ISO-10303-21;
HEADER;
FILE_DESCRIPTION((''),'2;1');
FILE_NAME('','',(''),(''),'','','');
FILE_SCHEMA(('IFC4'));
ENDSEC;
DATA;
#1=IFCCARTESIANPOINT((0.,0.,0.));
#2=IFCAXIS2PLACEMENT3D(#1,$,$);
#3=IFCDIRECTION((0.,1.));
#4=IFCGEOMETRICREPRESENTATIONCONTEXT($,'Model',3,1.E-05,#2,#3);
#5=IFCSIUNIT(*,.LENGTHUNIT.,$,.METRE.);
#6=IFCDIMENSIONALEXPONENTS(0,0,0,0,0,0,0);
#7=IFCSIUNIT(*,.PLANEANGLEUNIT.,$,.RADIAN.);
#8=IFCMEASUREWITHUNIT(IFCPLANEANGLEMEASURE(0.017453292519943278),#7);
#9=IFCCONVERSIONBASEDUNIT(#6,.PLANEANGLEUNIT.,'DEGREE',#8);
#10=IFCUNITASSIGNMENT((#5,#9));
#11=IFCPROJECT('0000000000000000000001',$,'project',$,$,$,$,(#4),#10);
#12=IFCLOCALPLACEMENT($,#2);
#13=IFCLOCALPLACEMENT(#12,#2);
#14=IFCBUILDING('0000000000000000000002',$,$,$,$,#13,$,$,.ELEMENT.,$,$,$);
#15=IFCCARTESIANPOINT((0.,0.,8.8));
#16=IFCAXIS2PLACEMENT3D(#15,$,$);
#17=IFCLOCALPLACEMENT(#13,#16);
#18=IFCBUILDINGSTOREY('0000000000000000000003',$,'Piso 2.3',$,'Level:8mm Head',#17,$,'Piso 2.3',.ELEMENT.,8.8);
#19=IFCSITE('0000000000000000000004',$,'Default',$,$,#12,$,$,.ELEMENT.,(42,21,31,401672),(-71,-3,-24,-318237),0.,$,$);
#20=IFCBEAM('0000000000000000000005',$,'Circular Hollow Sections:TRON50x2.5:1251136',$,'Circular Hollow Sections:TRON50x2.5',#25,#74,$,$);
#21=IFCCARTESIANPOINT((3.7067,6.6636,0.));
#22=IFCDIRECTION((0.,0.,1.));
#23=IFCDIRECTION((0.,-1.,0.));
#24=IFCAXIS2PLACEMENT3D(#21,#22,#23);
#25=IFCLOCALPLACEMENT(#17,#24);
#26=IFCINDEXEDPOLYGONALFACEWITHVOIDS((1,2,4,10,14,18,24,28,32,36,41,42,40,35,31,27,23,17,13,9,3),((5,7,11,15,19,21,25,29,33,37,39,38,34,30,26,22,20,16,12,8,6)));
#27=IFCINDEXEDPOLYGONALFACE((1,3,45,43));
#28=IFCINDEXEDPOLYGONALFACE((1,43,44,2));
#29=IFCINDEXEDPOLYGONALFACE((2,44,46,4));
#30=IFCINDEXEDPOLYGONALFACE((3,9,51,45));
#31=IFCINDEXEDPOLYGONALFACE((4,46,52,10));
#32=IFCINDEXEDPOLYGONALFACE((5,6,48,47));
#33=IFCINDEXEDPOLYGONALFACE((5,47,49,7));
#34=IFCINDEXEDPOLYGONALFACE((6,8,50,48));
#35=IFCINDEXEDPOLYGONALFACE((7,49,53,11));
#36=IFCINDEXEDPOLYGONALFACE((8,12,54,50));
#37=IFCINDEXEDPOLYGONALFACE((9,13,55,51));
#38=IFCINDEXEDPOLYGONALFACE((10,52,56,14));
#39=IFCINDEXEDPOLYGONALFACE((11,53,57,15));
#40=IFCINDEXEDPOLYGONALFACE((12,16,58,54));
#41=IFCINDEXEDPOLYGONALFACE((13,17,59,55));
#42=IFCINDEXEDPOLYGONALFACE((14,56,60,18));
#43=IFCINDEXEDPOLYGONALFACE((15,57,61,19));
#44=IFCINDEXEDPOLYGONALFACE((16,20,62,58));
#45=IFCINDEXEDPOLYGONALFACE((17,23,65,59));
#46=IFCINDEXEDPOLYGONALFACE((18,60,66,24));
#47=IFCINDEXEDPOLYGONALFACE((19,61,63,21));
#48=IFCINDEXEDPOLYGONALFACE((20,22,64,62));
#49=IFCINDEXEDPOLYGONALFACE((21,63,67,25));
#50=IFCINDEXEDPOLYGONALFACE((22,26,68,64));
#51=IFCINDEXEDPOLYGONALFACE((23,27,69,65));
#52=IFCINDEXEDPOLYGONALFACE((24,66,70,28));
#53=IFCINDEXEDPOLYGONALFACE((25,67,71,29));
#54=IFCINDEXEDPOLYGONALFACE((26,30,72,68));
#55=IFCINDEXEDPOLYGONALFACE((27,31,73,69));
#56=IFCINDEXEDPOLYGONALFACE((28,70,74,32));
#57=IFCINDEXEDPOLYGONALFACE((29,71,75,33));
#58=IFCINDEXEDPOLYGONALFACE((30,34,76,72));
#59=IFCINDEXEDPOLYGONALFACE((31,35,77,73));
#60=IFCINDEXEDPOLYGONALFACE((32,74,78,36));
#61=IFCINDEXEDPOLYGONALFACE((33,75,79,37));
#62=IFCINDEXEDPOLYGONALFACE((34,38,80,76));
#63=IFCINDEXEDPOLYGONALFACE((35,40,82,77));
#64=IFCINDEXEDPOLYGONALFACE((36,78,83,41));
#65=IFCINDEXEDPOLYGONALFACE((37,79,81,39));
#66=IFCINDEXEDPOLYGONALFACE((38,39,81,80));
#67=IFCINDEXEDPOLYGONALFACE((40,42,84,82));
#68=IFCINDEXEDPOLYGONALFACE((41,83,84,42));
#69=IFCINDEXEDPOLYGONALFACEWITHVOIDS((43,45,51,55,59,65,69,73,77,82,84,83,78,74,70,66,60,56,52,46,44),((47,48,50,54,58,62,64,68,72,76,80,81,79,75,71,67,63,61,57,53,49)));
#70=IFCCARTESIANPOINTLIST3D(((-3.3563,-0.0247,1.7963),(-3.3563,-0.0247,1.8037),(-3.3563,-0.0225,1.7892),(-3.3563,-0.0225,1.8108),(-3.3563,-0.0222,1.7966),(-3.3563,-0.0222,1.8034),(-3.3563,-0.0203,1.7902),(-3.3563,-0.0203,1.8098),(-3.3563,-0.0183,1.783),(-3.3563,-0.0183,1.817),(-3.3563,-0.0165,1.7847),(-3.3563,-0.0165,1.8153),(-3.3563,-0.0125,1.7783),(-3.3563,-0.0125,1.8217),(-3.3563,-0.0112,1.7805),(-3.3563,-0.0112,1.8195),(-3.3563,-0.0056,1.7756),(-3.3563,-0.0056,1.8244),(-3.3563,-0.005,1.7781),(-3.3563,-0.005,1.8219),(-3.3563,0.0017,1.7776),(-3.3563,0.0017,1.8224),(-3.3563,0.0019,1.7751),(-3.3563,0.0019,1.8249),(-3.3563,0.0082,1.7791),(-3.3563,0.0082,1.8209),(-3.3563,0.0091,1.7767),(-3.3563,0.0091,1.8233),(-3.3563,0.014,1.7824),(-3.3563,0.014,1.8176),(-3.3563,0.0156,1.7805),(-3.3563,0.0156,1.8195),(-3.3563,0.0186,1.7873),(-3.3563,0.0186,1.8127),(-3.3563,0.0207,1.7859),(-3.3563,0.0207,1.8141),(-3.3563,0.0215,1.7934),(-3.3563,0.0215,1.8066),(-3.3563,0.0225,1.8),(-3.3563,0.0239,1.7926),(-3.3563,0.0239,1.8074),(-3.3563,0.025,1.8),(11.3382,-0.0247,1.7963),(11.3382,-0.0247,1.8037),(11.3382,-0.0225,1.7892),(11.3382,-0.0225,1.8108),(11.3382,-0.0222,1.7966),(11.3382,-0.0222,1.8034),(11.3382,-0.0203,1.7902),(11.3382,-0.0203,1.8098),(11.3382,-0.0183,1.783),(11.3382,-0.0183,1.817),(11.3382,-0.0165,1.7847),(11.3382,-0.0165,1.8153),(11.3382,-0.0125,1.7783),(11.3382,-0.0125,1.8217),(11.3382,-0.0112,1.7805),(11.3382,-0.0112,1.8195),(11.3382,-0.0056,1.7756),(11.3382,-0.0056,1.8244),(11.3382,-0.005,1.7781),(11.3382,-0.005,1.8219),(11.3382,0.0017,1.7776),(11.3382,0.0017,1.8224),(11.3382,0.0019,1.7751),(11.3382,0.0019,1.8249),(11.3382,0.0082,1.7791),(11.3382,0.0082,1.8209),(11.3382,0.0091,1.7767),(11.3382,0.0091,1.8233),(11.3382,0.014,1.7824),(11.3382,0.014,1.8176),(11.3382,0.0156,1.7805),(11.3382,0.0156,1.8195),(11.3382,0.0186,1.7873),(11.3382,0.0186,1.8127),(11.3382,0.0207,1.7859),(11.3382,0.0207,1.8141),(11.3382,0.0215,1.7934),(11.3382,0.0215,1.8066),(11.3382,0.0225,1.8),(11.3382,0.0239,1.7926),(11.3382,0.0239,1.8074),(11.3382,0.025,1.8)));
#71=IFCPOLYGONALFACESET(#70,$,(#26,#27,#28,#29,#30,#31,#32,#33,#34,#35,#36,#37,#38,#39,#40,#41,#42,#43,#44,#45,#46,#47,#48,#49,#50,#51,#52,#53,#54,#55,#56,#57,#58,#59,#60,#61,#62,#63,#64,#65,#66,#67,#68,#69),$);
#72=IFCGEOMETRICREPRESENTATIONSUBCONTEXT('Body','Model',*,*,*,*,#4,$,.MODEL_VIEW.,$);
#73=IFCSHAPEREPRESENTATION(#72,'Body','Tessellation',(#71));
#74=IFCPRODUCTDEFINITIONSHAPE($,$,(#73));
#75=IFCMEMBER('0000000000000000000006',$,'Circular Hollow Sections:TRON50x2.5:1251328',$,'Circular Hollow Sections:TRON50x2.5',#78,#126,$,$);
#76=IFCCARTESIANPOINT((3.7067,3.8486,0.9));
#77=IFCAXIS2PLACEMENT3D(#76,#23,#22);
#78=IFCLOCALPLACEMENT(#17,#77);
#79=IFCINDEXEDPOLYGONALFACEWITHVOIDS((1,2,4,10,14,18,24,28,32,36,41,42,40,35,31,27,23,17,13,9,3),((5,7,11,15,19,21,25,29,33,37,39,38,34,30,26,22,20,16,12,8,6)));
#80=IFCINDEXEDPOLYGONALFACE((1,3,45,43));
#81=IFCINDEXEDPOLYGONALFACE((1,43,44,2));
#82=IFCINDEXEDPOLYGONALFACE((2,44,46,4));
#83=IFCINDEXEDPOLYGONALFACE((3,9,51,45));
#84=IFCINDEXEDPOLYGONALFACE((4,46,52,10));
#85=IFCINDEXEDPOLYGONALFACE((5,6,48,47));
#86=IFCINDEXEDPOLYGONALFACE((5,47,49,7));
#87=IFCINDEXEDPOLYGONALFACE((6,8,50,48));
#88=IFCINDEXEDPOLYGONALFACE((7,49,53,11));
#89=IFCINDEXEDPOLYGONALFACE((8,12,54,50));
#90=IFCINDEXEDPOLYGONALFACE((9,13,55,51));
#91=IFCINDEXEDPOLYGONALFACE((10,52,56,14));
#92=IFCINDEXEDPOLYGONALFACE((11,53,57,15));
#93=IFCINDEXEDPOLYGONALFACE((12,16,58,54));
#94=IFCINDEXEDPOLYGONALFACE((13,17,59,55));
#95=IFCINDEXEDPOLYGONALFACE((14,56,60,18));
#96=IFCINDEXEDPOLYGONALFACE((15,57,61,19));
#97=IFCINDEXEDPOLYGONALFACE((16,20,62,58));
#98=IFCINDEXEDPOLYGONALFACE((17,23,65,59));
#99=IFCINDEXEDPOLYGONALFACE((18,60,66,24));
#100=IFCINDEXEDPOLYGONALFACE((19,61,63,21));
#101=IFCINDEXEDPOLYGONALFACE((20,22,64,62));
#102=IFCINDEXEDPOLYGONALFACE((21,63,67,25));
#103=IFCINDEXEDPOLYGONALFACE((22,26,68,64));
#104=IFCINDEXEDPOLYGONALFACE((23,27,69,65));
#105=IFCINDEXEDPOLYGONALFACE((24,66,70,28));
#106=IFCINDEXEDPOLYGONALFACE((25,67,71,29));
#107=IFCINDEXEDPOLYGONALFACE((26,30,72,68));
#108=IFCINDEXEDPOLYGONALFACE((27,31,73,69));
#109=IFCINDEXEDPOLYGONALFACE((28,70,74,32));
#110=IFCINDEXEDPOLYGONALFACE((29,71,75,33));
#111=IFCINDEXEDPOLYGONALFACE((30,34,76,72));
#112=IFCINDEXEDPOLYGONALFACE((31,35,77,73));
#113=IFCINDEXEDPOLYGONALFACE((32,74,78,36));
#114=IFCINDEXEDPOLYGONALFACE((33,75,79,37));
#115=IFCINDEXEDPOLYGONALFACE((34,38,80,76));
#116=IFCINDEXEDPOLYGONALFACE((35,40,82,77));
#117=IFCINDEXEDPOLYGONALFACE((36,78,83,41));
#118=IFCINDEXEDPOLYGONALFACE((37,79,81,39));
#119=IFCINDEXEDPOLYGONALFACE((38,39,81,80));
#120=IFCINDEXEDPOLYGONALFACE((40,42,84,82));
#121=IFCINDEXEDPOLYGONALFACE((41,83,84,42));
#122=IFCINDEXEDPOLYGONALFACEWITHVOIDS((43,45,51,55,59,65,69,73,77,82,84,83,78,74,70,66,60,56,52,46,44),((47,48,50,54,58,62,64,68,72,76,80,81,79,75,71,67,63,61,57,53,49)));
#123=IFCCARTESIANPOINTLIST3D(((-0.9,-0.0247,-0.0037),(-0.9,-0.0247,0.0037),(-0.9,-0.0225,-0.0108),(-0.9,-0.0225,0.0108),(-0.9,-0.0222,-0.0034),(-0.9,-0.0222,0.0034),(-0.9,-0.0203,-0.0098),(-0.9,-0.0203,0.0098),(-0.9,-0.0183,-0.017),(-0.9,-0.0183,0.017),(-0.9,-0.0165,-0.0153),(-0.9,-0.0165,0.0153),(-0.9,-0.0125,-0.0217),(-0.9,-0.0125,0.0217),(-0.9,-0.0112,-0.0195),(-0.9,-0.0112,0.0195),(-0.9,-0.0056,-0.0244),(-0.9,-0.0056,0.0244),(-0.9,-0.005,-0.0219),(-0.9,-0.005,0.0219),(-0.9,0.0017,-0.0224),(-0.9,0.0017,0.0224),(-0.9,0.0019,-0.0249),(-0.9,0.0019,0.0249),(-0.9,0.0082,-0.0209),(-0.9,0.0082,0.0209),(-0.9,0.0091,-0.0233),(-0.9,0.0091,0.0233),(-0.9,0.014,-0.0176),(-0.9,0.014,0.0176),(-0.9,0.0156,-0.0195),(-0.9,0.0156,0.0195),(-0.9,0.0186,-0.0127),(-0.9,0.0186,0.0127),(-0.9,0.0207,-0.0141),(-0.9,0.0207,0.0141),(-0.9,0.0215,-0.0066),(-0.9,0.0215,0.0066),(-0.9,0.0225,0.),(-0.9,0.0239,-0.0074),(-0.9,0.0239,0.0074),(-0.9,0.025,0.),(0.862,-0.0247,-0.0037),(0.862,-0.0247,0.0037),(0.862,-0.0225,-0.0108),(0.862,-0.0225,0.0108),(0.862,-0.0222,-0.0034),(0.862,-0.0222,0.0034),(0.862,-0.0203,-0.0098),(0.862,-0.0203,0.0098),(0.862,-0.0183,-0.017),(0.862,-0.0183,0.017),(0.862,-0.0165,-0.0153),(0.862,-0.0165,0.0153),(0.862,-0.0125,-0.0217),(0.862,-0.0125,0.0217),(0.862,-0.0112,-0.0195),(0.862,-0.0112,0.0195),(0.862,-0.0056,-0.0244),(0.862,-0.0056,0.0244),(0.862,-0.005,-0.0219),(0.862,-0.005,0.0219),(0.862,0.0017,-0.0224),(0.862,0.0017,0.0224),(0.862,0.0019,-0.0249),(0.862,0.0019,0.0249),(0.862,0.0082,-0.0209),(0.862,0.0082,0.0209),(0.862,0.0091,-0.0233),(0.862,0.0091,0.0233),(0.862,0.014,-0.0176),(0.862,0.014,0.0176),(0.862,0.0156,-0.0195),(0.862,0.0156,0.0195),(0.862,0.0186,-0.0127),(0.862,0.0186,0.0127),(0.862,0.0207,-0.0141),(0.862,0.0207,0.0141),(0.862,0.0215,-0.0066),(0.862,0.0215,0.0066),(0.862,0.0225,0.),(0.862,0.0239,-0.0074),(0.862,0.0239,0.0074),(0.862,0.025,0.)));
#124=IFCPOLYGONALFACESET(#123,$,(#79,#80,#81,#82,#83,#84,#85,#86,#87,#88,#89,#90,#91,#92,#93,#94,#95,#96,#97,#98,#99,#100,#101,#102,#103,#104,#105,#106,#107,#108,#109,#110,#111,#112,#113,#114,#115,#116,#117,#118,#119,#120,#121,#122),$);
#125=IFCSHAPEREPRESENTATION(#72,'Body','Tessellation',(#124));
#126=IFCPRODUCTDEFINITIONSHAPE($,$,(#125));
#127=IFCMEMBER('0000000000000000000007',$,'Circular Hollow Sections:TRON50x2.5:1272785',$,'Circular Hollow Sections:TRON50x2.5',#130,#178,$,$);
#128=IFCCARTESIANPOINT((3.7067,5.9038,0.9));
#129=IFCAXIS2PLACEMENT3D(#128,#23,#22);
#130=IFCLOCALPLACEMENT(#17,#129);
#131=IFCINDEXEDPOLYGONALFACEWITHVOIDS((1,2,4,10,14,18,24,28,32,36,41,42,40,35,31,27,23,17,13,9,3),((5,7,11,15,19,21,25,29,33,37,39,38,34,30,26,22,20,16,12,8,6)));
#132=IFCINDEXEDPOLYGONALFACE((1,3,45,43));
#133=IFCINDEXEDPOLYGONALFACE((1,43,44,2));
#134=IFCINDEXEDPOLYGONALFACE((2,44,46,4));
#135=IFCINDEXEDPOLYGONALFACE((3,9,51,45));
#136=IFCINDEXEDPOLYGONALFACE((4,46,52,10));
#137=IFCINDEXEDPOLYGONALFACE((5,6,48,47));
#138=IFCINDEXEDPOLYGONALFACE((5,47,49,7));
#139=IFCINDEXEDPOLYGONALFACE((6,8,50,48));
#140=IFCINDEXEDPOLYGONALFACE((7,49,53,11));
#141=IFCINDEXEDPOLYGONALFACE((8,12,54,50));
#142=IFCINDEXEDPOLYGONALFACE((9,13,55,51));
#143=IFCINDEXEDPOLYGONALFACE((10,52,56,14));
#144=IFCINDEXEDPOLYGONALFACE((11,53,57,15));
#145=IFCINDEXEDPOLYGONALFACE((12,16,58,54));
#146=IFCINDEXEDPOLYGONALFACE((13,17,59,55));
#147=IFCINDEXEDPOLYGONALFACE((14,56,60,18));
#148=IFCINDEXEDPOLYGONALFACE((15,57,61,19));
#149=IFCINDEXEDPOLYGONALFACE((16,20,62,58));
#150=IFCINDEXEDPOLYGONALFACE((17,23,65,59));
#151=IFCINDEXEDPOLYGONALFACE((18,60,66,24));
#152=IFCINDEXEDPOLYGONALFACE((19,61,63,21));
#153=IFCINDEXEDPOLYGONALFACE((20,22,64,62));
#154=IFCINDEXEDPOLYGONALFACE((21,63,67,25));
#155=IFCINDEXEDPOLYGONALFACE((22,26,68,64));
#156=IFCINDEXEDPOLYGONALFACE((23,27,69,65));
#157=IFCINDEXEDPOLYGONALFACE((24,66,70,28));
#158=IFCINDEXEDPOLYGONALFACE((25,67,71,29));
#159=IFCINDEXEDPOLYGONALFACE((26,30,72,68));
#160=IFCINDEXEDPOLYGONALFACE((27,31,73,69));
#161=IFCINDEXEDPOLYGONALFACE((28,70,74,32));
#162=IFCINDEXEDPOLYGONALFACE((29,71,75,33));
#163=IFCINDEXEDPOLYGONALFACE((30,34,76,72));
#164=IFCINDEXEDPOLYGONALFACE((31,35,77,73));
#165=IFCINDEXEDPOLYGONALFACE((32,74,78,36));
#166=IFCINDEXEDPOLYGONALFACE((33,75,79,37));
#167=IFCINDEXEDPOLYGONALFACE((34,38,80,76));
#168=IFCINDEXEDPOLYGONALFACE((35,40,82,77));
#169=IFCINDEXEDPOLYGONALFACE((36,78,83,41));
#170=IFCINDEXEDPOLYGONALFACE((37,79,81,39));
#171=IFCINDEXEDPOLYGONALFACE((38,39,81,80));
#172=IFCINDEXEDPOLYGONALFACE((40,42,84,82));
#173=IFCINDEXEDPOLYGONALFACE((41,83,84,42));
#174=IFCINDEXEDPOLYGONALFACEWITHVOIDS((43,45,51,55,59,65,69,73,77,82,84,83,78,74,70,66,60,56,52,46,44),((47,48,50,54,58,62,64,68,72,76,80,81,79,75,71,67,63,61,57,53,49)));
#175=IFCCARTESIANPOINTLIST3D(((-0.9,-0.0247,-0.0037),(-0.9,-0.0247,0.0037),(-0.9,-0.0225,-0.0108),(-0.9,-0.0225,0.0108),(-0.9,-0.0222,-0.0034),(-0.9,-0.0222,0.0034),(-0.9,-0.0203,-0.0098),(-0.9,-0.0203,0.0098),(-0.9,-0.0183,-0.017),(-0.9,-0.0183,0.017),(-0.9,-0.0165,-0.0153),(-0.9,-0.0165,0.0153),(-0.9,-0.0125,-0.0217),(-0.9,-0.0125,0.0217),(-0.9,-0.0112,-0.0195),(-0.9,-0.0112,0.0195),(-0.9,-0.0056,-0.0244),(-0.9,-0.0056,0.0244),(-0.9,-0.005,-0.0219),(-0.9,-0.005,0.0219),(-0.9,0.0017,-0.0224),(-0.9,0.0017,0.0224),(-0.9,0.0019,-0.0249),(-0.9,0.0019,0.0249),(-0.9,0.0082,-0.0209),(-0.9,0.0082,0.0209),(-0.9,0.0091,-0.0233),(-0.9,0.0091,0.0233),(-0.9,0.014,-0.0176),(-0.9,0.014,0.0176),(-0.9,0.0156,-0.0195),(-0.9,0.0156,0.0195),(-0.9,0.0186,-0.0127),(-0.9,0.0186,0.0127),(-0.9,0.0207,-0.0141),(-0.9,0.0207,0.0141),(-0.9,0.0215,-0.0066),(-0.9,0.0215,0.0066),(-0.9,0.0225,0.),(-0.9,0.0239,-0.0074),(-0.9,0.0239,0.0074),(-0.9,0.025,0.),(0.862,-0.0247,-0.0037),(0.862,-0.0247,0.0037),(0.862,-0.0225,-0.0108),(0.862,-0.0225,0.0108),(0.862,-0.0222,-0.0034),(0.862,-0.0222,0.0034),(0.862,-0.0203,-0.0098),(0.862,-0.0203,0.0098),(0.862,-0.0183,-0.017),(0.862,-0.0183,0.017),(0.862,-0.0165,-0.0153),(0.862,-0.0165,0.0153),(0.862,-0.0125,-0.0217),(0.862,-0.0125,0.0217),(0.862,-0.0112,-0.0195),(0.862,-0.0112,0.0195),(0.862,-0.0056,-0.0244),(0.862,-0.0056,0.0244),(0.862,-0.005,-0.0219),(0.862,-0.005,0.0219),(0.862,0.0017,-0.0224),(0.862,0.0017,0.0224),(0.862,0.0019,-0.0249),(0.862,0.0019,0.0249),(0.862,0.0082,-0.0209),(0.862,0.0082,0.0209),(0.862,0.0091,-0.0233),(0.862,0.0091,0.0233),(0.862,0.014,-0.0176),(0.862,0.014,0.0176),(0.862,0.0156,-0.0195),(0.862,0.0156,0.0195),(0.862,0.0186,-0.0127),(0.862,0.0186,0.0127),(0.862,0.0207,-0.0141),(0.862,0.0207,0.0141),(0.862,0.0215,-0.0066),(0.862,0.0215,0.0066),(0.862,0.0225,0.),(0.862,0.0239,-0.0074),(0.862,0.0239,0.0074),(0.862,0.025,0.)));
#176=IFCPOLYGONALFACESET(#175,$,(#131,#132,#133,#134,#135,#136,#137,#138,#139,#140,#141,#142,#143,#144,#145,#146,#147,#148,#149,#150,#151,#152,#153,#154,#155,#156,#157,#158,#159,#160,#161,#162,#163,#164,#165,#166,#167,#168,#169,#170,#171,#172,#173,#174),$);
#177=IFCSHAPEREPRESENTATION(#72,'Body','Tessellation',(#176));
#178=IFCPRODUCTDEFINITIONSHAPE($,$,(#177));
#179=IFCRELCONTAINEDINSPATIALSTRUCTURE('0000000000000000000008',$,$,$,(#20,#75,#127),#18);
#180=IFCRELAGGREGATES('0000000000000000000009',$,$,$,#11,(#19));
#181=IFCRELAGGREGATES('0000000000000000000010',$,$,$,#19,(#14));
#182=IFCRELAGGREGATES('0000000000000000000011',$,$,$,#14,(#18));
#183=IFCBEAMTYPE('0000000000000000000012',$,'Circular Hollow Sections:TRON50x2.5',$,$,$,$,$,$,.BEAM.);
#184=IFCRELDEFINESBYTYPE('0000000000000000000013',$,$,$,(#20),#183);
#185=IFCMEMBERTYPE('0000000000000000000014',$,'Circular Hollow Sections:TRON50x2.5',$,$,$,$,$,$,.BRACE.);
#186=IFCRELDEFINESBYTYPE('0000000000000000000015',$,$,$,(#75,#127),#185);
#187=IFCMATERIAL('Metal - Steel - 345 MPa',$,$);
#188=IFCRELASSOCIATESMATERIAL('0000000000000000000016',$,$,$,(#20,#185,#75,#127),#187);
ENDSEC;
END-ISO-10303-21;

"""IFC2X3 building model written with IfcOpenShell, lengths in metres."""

from ifc_helpers import new_model, entity, si_unit, converted_unit, direction, frame, frame_2d, origin, origin_2d_with_axis, place, context, subcontext, project, spatial, hollow_circle, extrude, source, transform, mapped, material, type_object, type_shapes, element, save


model = new_model("IFC2X3")

# Units and contexts
model_context = context("Model", 3, precision=1e-05, world=origin(), true_north=direction((0.0, 1.0)))
body_context = subcontext(model_context, "Body", "Model", "MODEL_VIEW")
ifc_project = project(units=[si_unit("LENGTHUNIT", "METRE"), converted_unit("PLANEANGLEUNIT", "DEGREE", entity("IfcPlaneAngleMeasure", 0.017453292519943278), si_unit("PLANEANGLEUNIT", "RADIAN"), dimensions=[0, 0, 0, 0, 0, 0, 0])], contexts=[model_context])

# Site, building, storey
site_placement = place(None, origin())
site = spatial("IfcSite", under=ifc_project, at=site_placement, Name="Default", CompositionType="ELEMENT", RefLatitude=(42, 21, 31, 401672), RefLongitude=(-71, -3, -24, -318237), RefElevation=0.0)
building_placement = place(site_placement, origin())
building = spatial("IfcBuilding", under=site, at=building_placement, CompositionType="ELEMENT")
storey_placement = place(building_placement, frame((0.0, 0.0, 8.8)))
storey = spatial("IfcBuildingStorey", under=building, at=storey_placement, Name="Piso 2.3", ObjectType="Level:8mm Head", LongName="Piso 2.3", CompositionType="ELEMENT", Elevation=8.8)

# Shared definitions
ifc_material = material(Name="Metal - Steel - 345 MPa")

# Beam
beam_type_1 = type_object("IfcBeamType", Name="Circular Hollow Sections:TRON50x2.5", PredefinedType="BEAM")
beam_1_placement = place(storey_placement, frame((3.7067, 6.6636, 0.0), z_axis=(0.0, 0.0, 1.0), x_axis=(0.0, -1.0, 0.0)))
element("IfcBeam", 1, at=beam_1_placement, inside=storey, type_object=beam_type_1, material=ifc_material, Name="Circular Hollow Sections:TRON50x2.5:1251136", ObjectType="Circular Hollow Sections:TRON50x2.5", context=body_context, shape_type="SweptSolid", body=[
    extrude(hollow_circle(Radius=0.025, WallThickness=0.0025, at=origin_2d_with_axis()), frame((-3.3563, 0.0, 1.8), z_axis=(1.0, 0.0, 0.0), x_axis=(0.0, 1.0, 0.0)), (0.0, 0.0, 1.0), 14.6946),
])

# Members
member_type_1 = type_object("IfcMemberType", Name="Circular Hollow Sections:TRON50x2.5", PredefinedType="BRACE", material=ifc_material)
shared_shape_1 = source(origin(), body_context, "Body", "SweptSolid", [
    extrude(hollow_circle(Radius=0.025, WallThickness=0.0025, at=frame_2d((0.0, 0.0), x_axis=(1.0, 0.0))), frame((-0.9, 0.0, 0.0), z_axis=(1.0, 0.0, 0.0), x_axis=(0.0, 1.0, 0.0)), (0.0, 0.0, 1.0), 1.762),
])
type_shapes(member_type_1, [shared_shape_1])
for number, where, z_axis, x_axis, name in (
    (2, (3.7067, 3.8486, 0.9), (0.0, -1.0, 0.0), (0.0, 0.0, 1.0), "Circular Hollow Sections:TRON50x2.5:1251328"),
    (3, (3.7067, 5.9038, 0.9), (0.0, -1.0, 0.0), (0.0, 0.0, 1.0), "Circular Hollow Sections:TRON50x2.5:1272785"),
):
    element("IfcMember", number, at=place(storey_placement, frame(where, z_axis=z_axis, x_axis=x_axis)), inside=storey, type_object=member_type_1, material=ifc_material, Name=name, ObjectType="Circular Hollow Sections:TRON50x2.5", context=body_context, shape_type="MappedRepresentation", body=[
        mapped(shared_shape_1, transform((0.0, 0.0, 0.0), scale=1.0)),
    ])

save(model, "model.ifc")
